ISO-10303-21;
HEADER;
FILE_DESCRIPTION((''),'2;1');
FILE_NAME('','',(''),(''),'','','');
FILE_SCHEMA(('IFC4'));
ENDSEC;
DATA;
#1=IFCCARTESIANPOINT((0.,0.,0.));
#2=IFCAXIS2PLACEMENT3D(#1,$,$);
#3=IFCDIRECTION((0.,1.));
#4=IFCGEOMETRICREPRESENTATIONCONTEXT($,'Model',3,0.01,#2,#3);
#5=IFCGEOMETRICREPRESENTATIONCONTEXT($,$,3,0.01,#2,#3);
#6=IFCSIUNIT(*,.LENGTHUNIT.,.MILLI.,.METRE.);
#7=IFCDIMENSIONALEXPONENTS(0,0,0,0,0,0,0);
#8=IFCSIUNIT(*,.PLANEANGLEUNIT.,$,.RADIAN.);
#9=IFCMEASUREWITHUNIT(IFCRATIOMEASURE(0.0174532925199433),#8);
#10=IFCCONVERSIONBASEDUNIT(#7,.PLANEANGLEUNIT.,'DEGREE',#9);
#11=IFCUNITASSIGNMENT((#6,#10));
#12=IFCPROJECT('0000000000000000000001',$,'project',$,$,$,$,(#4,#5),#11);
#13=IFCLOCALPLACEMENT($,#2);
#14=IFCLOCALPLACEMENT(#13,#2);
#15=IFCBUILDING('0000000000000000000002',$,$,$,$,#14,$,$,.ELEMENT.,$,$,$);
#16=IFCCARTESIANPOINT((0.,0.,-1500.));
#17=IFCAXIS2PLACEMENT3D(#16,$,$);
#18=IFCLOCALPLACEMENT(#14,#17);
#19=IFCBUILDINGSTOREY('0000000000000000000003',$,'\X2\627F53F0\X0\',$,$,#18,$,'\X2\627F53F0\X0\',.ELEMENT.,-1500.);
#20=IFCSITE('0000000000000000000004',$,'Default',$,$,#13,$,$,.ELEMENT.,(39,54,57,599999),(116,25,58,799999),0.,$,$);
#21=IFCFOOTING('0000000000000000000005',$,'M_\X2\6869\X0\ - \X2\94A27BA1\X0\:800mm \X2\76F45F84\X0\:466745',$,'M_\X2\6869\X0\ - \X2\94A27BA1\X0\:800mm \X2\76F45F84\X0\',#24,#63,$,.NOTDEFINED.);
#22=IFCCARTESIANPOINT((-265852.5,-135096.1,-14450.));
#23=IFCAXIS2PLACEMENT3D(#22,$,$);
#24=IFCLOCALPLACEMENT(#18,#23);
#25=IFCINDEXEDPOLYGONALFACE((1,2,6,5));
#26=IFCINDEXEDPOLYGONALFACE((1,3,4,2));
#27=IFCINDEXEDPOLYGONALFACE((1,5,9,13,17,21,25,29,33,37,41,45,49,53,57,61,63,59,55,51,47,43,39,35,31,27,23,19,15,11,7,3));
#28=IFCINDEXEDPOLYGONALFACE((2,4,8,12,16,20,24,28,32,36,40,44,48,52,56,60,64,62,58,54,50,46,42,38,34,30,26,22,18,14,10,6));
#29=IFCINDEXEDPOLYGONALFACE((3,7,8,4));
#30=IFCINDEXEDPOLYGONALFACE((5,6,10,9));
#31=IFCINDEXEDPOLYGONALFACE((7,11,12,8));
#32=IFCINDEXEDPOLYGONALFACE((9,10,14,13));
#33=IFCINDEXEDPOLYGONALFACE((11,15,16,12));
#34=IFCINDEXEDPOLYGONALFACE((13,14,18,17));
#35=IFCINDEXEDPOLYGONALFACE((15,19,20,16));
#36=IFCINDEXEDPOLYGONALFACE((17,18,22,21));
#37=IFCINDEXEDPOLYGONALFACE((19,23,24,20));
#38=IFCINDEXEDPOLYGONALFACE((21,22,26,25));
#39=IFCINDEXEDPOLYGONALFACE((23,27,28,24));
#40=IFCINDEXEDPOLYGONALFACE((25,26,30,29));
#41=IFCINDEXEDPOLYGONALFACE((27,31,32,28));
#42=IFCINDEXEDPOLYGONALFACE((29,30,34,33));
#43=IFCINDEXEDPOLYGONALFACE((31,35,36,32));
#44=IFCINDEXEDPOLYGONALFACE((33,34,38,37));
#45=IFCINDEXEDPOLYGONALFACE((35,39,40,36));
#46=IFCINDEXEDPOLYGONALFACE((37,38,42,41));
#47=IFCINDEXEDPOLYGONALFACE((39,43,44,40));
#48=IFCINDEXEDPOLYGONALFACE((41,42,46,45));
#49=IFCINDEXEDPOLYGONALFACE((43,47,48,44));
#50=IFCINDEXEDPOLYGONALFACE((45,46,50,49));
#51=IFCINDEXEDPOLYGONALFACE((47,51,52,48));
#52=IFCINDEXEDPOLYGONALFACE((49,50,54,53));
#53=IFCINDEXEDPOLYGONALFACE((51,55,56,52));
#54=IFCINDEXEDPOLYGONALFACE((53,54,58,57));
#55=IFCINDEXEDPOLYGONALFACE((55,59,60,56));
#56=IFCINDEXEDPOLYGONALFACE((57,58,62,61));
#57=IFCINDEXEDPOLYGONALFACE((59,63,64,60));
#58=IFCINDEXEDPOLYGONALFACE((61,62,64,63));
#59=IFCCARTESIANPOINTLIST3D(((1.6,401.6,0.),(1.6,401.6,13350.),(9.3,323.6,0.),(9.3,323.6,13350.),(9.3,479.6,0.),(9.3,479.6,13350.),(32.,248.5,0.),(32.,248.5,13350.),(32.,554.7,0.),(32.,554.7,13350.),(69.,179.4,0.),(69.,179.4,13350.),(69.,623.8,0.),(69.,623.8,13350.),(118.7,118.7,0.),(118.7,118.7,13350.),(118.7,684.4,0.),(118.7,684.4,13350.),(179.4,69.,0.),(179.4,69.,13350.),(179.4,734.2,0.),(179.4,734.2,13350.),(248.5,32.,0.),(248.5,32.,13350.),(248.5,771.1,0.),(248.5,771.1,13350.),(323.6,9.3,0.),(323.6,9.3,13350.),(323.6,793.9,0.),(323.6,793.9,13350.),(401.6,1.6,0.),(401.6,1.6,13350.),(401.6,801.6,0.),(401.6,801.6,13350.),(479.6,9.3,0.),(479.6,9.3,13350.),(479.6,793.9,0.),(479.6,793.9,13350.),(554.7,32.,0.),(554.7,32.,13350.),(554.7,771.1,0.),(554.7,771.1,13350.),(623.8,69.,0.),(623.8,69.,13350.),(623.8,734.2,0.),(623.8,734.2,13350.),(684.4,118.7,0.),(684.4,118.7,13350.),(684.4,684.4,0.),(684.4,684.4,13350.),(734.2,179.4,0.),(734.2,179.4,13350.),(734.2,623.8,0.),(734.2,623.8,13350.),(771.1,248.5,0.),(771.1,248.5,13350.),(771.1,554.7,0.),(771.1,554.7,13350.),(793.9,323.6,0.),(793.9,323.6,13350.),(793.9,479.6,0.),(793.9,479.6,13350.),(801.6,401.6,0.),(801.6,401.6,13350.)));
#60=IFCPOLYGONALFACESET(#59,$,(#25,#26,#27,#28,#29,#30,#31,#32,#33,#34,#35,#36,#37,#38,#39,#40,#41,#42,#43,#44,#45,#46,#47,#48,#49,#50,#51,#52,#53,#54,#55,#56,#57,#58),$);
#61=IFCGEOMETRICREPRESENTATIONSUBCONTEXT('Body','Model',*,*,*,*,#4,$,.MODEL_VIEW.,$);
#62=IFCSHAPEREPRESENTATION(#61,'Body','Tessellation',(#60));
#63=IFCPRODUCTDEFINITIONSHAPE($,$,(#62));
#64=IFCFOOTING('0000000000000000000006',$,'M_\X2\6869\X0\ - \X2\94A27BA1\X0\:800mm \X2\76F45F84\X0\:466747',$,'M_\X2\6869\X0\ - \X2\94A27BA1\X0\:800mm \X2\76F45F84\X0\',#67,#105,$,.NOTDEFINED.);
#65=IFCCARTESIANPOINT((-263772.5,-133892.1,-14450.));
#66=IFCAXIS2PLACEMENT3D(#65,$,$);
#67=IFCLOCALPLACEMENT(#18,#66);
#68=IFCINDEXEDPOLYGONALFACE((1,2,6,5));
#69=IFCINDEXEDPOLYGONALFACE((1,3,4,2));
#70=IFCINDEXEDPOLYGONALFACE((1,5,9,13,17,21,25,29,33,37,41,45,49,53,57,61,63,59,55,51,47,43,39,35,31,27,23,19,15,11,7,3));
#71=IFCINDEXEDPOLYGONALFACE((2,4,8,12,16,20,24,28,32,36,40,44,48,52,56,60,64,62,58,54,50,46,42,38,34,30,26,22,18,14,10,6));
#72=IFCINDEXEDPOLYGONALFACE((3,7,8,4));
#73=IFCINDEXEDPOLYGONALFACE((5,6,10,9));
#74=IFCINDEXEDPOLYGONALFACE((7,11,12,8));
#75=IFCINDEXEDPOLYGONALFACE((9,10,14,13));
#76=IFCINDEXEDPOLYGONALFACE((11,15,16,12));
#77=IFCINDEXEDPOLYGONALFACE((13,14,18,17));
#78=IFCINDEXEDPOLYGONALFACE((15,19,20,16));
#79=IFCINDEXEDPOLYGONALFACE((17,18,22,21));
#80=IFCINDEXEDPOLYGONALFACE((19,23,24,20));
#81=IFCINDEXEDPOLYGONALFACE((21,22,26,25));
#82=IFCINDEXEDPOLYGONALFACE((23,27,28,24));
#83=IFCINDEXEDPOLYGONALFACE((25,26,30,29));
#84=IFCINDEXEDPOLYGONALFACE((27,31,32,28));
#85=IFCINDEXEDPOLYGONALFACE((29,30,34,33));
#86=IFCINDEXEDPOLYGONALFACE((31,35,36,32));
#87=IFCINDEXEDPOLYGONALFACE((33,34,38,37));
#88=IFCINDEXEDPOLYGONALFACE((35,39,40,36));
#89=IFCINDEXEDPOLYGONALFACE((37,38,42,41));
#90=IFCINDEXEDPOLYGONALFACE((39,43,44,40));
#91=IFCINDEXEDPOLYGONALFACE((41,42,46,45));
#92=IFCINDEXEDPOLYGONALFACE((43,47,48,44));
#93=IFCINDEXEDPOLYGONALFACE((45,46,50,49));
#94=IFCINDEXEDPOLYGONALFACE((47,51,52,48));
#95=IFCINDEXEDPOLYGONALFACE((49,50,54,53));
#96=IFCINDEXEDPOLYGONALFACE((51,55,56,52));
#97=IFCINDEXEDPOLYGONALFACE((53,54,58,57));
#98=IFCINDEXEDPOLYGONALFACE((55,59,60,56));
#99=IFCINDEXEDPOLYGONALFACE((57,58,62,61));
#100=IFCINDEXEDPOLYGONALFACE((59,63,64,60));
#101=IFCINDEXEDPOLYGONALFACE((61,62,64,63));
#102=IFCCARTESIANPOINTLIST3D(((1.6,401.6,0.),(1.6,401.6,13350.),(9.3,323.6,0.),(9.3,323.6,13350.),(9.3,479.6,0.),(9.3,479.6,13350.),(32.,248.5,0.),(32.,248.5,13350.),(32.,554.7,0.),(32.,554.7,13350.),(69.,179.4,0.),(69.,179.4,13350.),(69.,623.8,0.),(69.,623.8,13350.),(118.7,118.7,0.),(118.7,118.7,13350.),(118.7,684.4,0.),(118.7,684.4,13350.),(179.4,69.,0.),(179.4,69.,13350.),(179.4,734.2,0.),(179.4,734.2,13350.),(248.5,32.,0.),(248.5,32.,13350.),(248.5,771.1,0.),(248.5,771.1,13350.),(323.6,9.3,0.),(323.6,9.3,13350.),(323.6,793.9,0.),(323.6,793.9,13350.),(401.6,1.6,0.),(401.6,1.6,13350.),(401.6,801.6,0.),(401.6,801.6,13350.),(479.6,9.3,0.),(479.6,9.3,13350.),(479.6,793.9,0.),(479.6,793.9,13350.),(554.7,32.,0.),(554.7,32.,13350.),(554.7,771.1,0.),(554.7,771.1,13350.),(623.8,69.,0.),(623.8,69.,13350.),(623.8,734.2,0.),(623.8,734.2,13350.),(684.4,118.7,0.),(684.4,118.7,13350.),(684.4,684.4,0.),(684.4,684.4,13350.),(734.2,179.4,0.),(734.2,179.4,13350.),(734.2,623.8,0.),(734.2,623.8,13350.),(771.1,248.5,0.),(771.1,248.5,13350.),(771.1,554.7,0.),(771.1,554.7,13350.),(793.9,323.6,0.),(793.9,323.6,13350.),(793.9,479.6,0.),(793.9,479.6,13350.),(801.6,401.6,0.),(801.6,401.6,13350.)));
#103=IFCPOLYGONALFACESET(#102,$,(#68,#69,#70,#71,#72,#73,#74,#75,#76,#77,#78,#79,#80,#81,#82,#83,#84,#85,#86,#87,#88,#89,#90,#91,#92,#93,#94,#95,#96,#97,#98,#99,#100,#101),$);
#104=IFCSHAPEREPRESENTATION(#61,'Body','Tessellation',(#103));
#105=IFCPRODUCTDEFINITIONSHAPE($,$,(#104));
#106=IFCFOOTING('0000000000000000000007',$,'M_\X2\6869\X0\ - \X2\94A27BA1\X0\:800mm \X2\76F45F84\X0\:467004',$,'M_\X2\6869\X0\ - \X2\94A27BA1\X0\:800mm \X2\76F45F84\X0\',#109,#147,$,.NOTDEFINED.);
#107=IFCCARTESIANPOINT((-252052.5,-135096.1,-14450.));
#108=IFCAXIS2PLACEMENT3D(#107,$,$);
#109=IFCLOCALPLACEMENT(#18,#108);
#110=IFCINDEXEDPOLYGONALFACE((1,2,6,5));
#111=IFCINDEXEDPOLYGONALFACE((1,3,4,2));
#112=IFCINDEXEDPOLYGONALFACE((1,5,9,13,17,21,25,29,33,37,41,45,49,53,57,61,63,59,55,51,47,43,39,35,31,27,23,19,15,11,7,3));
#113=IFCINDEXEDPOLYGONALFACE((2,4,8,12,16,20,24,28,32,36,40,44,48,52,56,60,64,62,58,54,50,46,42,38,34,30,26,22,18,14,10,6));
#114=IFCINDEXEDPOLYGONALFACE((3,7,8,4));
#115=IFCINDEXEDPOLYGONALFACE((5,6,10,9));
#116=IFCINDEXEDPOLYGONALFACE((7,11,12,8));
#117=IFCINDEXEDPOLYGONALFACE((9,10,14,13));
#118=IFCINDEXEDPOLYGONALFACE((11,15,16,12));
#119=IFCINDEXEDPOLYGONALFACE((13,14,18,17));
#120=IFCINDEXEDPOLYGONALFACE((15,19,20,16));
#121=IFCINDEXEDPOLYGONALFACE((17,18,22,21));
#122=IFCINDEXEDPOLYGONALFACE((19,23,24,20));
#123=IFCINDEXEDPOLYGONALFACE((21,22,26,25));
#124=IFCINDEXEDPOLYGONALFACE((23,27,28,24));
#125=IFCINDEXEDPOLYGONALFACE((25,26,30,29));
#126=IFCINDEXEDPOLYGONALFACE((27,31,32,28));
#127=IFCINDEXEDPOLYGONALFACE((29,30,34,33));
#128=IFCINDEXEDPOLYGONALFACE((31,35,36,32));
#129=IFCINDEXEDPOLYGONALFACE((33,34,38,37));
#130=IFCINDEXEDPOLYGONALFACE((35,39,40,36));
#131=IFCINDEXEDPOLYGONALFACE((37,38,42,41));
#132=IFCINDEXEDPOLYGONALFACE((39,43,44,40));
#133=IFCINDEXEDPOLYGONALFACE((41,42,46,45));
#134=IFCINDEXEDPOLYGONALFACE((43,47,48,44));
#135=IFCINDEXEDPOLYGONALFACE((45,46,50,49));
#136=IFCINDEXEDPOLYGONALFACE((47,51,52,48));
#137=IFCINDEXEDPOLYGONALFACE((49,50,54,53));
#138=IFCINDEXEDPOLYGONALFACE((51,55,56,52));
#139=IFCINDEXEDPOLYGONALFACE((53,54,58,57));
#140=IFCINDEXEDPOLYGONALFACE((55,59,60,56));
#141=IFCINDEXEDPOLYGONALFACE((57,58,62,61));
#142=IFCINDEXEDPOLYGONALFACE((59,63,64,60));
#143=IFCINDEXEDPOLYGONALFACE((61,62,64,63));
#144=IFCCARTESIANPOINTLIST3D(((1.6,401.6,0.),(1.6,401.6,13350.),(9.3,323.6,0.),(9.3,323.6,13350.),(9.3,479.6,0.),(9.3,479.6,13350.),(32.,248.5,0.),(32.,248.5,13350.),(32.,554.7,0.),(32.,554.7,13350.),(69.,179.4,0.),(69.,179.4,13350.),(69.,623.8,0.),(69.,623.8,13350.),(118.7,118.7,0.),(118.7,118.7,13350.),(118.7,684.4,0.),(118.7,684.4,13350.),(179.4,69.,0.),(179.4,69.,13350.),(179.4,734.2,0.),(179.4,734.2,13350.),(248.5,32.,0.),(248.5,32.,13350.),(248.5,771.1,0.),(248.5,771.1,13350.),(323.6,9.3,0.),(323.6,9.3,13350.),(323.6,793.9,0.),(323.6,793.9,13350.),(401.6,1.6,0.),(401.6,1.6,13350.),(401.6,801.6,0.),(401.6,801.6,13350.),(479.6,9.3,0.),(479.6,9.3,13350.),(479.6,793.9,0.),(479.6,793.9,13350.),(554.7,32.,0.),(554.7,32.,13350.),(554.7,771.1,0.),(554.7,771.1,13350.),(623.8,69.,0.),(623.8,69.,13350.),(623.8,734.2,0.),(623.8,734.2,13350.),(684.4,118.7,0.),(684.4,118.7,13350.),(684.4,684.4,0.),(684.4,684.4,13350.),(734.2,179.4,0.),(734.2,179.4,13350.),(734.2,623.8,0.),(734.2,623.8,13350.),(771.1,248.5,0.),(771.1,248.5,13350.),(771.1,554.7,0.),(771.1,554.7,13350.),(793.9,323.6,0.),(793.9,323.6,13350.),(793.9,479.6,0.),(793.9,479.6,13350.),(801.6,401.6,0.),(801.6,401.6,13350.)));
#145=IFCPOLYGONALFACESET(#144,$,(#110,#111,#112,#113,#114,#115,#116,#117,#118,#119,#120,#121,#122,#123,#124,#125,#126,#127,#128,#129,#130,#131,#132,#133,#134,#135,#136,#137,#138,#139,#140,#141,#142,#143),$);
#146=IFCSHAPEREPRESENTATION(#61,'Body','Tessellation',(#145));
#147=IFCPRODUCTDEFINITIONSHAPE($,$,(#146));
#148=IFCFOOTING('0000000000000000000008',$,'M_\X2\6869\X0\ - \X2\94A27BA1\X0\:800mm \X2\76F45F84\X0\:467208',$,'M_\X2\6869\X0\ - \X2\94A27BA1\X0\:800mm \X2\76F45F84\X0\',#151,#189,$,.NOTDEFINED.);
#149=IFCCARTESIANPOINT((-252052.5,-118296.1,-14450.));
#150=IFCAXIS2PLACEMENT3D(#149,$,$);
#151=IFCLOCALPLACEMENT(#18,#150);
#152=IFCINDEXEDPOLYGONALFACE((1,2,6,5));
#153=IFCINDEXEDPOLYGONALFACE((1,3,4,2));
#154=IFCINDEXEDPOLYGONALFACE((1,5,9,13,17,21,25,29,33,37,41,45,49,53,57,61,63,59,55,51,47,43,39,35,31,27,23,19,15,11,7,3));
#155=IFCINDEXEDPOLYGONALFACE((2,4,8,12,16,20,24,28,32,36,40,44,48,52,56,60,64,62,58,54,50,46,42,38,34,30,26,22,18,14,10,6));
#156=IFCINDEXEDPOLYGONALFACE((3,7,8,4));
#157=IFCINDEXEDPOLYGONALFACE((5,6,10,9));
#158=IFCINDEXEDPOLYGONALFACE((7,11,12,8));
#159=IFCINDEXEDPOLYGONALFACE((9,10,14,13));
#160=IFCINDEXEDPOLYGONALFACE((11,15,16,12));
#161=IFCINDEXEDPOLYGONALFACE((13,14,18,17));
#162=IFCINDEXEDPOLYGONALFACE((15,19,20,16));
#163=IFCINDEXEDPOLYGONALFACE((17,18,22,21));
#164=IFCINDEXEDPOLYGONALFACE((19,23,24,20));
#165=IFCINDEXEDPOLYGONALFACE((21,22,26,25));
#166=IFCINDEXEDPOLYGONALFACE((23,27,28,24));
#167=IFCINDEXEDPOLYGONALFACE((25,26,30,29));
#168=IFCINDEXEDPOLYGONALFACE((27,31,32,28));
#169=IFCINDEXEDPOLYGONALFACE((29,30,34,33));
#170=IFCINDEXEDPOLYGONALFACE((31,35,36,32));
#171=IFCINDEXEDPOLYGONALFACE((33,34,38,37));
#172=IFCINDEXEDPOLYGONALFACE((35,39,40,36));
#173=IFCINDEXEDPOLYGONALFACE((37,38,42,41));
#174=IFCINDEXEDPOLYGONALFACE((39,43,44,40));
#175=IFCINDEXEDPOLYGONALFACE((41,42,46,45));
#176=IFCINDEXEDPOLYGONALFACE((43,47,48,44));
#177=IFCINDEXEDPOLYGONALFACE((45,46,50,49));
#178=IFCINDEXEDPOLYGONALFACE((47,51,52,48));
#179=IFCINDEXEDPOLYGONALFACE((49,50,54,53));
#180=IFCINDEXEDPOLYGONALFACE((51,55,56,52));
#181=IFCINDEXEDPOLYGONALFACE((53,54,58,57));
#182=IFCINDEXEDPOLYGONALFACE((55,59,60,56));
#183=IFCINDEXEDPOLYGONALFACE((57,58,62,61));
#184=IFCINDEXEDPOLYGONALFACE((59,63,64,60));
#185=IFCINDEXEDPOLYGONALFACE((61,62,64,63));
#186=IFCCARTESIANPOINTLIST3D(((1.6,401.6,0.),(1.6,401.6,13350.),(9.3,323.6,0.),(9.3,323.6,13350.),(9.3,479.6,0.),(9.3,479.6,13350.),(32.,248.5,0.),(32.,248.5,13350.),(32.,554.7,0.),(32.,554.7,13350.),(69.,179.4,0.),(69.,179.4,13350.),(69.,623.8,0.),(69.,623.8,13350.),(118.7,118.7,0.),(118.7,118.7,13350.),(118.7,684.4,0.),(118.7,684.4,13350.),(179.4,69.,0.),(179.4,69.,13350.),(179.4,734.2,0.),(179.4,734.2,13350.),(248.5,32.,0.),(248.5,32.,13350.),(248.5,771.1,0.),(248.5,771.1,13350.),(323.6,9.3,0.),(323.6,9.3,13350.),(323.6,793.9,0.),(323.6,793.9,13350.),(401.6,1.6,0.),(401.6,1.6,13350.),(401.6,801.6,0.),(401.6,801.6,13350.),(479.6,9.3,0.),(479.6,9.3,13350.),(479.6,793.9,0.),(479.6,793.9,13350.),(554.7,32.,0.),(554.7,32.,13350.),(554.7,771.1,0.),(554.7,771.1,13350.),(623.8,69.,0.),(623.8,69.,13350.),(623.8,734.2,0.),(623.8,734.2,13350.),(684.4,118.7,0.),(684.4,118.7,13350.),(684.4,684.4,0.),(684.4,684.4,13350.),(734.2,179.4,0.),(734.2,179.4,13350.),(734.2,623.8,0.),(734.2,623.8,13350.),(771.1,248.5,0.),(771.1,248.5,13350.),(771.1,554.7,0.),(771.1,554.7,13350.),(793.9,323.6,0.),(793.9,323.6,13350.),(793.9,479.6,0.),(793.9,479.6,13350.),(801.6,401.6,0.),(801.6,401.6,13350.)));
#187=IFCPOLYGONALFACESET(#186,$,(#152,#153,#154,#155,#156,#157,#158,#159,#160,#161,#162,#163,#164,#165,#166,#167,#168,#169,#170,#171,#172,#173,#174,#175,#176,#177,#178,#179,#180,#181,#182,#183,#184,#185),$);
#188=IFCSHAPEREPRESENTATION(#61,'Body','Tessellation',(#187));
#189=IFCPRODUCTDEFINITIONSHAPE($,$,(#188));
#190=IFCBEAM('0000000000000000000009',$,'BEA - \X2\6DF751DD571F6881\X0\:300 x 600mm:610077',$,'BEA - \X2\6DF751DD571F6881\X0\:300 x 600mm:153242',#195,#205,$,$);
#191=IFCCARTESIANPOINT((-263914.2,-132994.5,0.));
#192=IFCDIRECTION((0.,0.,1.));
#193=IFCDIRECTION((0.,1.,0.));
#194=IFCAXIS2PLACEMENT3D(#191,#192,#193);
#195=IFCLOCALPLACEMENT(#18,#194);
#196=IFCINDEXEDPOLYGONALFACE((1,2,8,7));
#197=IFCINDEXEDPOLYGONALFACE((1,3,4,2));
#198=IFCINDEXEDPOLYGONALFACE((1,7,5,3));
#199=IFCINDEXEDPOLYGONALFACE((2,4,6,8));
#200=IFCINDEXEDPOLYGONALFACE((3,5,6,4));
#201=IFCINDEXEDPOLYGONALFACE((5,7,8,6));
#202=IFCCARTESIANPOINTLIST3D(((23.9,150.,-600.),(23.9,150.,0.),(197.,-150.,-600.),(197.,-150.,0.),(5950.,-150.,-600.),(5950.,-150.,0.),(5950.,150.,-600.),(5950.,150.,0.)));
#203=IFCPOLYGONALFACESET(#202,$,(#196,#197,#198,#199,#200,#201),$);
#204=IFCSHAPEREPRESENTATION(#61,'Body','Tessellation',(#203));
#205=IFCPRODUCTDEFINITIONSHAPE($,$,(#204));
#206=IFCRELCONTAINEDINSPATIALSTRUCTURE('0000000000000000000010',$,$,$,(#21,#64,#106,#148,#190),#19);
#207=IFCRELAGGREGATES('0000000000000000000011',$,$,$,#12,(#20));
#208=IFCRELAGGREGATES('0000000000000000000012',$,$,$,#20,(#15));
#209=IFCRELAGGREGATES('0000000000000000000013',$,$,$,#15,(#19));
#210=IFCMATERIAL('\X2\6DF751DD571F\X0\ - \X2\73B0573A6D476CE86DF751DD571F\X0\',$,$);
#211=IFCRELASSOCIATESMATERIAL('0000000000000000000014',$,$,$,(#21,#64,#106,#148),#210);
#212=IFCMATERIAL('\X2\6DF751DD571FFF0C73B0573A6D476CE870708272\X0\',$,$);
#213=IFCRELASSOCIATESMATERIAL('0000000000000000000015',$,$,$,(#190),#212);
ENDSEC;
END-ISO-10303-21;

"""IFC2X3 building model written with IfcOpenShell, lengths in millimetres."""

from ifc_helpers import new_model, entity, si_unit, converted_unit, direction, frame, frame_2d, origin, origin_2d_with_axis, place, context, subcontext, project, spatial, rectangle, circle, extrude, clip, halfspace, material, element, save


model = new_model("IFC2X3")

# Units and contexts
model_context = context("Model", 3, precision=0.01, world=origin(), true_north=direction((0.0, 1.0)))
context_of_model = context(None, 3, precision=0.01, world=origin(), true_north=direction((0.0, 1.0)))
body_context = subcontext(model_context, "Body", "Model", "MODEL_VIEW")
ifc_project = project(units=[si_unit("LENGTHUNIT", "METRE", prefix="MILLI"), converted_unit("PLANEANGLEUNIT", "DEGREE", entity("IfcRatioMeasure", 0.0174532925199433), si_unit("PLANEANGLEUNIT", "RADIAN"), dimensions=[0, 0, 0, 0, 0, 0, 0])], contexts=[model_context, context_of_model])

# Site, building, storey
site_placement = place(None, origin())
site = spatial("IfcSite", under=ifc_project, at=site_placement, Name="Default", CompositionType="ELEMENT", RefLatitude=(39, 54, 57, 599999), RefLongitude=(116, 25, 58, 799999), RefElevation=0.0)
building_placement = place(site_placement, origin())
building = spatial("IfcBuilding", under=site, at=building_placement, CompositionType="ELEMENT")
storey_placement = place(building_placement, frame((0.0, 0.0, -1500.0)))
storey = spatial("IfcBuildingStorey", under=building, at=storey_placement, Name="承台", LongName="承台", CompositionType="ELEMENT", Elevation=-1500.0)

# Footings
ifc_material_1 = material(Name="混凝土 - 现场浇注混凝土")
for number, where, name in (
    (1, (-265852.5, -135096.1, -14450.0), "M_桩 - 钢管:800mm 直径:466745"),
    (2, (-263772.5, -133892.1, -14450.0), "M_桩 - 钢管:800mm 直径:466747"),
    (3, (-252052.5, -135096.1, -14450.0), "M_桩 - 钢管:800mm 直径:467004"),
):
    element("IfcFooting", number, at=place(storey_placement, frame(where)), inside=storey, material=ifc_material_1, Name=name, ObjectType="M_桩 - 钢管:800mm 直径", PredefinedType="NOTDEFINED", context=body_context, shape_type="SweptSolid", body=[
        extrude(circle(Radius=400.0, at=origin_2d_with_axis()), frame((401.6, 401.6, 0.0), z_axis=(0.0, 0.0, 1.0), x_axis=(0.0, 1.0, 0.0)), (0.0, 0.0, 1.0), 13350.0),
    ])
footing_1_placement = place(storey_placement, frame((-252052.5, -118296.1, -14450.0)))
element("IfcFooting", 4, at=footing_1_placement, inside=storey, material=ifc_material_1, Name="M_桩 - 钢管:800mm 直径:467208", ObjectType="M_桩 - 钢管:800mm 直径", PredefinedType="NOTDEFINED", context=body_context, shape_type="SweptSolid", body=[
    extrude(circle(Radius=400.0, at=origin_2d_with_axis()), frame((401.6, 401.6, 0.0), z_axis=(0.0, 0.0, 1.0), x_axis=(0.0, 1.0, 0.0)), (0.0, 0.0, 1.0), 13350.0),
])

# Shared definitions
ifc_material_2 = material(Name="混凝土，现场浇注灰色")

# Beam
beam_1_placement = place(storey_placement, frame((-263914.2, -132994.5, 0.0), z_axis=(0.0, 0.0, 1.0), x_axis=(0.0, 1.0, 0.0)))
element("IfcBeam", 5, at=beam_1_placement, inside=storey, material=ifc_material_2, Name="BEA - 混凝土梁:300 x 600mm:610077", ObjectType="BEA - 混凝土梁:300 x 600mm:153242", context=body_context, shape_type="Clipping", body=[
    clip(extrude(rectangle(XDim=600.0, YDim=300.0, at=frame_2d((0.0, 0.0), x_axis=(1.0, 0.0))), frame((23.9, 0.0, -300.0), z_axis=(1.0, 0.0, 0.0), x_axis=(0.0, 0.0, -1.0)), (0.0, 0.0, 1.0), 5926.1), halfspace(frame((424.0, -543.3, 0.0), z_axis=(-0.866125, -0.499827, 0.0), x_axis=(0.499827, -0.866125, 0.0)), False)),
])

save(model, "model.ifc")
